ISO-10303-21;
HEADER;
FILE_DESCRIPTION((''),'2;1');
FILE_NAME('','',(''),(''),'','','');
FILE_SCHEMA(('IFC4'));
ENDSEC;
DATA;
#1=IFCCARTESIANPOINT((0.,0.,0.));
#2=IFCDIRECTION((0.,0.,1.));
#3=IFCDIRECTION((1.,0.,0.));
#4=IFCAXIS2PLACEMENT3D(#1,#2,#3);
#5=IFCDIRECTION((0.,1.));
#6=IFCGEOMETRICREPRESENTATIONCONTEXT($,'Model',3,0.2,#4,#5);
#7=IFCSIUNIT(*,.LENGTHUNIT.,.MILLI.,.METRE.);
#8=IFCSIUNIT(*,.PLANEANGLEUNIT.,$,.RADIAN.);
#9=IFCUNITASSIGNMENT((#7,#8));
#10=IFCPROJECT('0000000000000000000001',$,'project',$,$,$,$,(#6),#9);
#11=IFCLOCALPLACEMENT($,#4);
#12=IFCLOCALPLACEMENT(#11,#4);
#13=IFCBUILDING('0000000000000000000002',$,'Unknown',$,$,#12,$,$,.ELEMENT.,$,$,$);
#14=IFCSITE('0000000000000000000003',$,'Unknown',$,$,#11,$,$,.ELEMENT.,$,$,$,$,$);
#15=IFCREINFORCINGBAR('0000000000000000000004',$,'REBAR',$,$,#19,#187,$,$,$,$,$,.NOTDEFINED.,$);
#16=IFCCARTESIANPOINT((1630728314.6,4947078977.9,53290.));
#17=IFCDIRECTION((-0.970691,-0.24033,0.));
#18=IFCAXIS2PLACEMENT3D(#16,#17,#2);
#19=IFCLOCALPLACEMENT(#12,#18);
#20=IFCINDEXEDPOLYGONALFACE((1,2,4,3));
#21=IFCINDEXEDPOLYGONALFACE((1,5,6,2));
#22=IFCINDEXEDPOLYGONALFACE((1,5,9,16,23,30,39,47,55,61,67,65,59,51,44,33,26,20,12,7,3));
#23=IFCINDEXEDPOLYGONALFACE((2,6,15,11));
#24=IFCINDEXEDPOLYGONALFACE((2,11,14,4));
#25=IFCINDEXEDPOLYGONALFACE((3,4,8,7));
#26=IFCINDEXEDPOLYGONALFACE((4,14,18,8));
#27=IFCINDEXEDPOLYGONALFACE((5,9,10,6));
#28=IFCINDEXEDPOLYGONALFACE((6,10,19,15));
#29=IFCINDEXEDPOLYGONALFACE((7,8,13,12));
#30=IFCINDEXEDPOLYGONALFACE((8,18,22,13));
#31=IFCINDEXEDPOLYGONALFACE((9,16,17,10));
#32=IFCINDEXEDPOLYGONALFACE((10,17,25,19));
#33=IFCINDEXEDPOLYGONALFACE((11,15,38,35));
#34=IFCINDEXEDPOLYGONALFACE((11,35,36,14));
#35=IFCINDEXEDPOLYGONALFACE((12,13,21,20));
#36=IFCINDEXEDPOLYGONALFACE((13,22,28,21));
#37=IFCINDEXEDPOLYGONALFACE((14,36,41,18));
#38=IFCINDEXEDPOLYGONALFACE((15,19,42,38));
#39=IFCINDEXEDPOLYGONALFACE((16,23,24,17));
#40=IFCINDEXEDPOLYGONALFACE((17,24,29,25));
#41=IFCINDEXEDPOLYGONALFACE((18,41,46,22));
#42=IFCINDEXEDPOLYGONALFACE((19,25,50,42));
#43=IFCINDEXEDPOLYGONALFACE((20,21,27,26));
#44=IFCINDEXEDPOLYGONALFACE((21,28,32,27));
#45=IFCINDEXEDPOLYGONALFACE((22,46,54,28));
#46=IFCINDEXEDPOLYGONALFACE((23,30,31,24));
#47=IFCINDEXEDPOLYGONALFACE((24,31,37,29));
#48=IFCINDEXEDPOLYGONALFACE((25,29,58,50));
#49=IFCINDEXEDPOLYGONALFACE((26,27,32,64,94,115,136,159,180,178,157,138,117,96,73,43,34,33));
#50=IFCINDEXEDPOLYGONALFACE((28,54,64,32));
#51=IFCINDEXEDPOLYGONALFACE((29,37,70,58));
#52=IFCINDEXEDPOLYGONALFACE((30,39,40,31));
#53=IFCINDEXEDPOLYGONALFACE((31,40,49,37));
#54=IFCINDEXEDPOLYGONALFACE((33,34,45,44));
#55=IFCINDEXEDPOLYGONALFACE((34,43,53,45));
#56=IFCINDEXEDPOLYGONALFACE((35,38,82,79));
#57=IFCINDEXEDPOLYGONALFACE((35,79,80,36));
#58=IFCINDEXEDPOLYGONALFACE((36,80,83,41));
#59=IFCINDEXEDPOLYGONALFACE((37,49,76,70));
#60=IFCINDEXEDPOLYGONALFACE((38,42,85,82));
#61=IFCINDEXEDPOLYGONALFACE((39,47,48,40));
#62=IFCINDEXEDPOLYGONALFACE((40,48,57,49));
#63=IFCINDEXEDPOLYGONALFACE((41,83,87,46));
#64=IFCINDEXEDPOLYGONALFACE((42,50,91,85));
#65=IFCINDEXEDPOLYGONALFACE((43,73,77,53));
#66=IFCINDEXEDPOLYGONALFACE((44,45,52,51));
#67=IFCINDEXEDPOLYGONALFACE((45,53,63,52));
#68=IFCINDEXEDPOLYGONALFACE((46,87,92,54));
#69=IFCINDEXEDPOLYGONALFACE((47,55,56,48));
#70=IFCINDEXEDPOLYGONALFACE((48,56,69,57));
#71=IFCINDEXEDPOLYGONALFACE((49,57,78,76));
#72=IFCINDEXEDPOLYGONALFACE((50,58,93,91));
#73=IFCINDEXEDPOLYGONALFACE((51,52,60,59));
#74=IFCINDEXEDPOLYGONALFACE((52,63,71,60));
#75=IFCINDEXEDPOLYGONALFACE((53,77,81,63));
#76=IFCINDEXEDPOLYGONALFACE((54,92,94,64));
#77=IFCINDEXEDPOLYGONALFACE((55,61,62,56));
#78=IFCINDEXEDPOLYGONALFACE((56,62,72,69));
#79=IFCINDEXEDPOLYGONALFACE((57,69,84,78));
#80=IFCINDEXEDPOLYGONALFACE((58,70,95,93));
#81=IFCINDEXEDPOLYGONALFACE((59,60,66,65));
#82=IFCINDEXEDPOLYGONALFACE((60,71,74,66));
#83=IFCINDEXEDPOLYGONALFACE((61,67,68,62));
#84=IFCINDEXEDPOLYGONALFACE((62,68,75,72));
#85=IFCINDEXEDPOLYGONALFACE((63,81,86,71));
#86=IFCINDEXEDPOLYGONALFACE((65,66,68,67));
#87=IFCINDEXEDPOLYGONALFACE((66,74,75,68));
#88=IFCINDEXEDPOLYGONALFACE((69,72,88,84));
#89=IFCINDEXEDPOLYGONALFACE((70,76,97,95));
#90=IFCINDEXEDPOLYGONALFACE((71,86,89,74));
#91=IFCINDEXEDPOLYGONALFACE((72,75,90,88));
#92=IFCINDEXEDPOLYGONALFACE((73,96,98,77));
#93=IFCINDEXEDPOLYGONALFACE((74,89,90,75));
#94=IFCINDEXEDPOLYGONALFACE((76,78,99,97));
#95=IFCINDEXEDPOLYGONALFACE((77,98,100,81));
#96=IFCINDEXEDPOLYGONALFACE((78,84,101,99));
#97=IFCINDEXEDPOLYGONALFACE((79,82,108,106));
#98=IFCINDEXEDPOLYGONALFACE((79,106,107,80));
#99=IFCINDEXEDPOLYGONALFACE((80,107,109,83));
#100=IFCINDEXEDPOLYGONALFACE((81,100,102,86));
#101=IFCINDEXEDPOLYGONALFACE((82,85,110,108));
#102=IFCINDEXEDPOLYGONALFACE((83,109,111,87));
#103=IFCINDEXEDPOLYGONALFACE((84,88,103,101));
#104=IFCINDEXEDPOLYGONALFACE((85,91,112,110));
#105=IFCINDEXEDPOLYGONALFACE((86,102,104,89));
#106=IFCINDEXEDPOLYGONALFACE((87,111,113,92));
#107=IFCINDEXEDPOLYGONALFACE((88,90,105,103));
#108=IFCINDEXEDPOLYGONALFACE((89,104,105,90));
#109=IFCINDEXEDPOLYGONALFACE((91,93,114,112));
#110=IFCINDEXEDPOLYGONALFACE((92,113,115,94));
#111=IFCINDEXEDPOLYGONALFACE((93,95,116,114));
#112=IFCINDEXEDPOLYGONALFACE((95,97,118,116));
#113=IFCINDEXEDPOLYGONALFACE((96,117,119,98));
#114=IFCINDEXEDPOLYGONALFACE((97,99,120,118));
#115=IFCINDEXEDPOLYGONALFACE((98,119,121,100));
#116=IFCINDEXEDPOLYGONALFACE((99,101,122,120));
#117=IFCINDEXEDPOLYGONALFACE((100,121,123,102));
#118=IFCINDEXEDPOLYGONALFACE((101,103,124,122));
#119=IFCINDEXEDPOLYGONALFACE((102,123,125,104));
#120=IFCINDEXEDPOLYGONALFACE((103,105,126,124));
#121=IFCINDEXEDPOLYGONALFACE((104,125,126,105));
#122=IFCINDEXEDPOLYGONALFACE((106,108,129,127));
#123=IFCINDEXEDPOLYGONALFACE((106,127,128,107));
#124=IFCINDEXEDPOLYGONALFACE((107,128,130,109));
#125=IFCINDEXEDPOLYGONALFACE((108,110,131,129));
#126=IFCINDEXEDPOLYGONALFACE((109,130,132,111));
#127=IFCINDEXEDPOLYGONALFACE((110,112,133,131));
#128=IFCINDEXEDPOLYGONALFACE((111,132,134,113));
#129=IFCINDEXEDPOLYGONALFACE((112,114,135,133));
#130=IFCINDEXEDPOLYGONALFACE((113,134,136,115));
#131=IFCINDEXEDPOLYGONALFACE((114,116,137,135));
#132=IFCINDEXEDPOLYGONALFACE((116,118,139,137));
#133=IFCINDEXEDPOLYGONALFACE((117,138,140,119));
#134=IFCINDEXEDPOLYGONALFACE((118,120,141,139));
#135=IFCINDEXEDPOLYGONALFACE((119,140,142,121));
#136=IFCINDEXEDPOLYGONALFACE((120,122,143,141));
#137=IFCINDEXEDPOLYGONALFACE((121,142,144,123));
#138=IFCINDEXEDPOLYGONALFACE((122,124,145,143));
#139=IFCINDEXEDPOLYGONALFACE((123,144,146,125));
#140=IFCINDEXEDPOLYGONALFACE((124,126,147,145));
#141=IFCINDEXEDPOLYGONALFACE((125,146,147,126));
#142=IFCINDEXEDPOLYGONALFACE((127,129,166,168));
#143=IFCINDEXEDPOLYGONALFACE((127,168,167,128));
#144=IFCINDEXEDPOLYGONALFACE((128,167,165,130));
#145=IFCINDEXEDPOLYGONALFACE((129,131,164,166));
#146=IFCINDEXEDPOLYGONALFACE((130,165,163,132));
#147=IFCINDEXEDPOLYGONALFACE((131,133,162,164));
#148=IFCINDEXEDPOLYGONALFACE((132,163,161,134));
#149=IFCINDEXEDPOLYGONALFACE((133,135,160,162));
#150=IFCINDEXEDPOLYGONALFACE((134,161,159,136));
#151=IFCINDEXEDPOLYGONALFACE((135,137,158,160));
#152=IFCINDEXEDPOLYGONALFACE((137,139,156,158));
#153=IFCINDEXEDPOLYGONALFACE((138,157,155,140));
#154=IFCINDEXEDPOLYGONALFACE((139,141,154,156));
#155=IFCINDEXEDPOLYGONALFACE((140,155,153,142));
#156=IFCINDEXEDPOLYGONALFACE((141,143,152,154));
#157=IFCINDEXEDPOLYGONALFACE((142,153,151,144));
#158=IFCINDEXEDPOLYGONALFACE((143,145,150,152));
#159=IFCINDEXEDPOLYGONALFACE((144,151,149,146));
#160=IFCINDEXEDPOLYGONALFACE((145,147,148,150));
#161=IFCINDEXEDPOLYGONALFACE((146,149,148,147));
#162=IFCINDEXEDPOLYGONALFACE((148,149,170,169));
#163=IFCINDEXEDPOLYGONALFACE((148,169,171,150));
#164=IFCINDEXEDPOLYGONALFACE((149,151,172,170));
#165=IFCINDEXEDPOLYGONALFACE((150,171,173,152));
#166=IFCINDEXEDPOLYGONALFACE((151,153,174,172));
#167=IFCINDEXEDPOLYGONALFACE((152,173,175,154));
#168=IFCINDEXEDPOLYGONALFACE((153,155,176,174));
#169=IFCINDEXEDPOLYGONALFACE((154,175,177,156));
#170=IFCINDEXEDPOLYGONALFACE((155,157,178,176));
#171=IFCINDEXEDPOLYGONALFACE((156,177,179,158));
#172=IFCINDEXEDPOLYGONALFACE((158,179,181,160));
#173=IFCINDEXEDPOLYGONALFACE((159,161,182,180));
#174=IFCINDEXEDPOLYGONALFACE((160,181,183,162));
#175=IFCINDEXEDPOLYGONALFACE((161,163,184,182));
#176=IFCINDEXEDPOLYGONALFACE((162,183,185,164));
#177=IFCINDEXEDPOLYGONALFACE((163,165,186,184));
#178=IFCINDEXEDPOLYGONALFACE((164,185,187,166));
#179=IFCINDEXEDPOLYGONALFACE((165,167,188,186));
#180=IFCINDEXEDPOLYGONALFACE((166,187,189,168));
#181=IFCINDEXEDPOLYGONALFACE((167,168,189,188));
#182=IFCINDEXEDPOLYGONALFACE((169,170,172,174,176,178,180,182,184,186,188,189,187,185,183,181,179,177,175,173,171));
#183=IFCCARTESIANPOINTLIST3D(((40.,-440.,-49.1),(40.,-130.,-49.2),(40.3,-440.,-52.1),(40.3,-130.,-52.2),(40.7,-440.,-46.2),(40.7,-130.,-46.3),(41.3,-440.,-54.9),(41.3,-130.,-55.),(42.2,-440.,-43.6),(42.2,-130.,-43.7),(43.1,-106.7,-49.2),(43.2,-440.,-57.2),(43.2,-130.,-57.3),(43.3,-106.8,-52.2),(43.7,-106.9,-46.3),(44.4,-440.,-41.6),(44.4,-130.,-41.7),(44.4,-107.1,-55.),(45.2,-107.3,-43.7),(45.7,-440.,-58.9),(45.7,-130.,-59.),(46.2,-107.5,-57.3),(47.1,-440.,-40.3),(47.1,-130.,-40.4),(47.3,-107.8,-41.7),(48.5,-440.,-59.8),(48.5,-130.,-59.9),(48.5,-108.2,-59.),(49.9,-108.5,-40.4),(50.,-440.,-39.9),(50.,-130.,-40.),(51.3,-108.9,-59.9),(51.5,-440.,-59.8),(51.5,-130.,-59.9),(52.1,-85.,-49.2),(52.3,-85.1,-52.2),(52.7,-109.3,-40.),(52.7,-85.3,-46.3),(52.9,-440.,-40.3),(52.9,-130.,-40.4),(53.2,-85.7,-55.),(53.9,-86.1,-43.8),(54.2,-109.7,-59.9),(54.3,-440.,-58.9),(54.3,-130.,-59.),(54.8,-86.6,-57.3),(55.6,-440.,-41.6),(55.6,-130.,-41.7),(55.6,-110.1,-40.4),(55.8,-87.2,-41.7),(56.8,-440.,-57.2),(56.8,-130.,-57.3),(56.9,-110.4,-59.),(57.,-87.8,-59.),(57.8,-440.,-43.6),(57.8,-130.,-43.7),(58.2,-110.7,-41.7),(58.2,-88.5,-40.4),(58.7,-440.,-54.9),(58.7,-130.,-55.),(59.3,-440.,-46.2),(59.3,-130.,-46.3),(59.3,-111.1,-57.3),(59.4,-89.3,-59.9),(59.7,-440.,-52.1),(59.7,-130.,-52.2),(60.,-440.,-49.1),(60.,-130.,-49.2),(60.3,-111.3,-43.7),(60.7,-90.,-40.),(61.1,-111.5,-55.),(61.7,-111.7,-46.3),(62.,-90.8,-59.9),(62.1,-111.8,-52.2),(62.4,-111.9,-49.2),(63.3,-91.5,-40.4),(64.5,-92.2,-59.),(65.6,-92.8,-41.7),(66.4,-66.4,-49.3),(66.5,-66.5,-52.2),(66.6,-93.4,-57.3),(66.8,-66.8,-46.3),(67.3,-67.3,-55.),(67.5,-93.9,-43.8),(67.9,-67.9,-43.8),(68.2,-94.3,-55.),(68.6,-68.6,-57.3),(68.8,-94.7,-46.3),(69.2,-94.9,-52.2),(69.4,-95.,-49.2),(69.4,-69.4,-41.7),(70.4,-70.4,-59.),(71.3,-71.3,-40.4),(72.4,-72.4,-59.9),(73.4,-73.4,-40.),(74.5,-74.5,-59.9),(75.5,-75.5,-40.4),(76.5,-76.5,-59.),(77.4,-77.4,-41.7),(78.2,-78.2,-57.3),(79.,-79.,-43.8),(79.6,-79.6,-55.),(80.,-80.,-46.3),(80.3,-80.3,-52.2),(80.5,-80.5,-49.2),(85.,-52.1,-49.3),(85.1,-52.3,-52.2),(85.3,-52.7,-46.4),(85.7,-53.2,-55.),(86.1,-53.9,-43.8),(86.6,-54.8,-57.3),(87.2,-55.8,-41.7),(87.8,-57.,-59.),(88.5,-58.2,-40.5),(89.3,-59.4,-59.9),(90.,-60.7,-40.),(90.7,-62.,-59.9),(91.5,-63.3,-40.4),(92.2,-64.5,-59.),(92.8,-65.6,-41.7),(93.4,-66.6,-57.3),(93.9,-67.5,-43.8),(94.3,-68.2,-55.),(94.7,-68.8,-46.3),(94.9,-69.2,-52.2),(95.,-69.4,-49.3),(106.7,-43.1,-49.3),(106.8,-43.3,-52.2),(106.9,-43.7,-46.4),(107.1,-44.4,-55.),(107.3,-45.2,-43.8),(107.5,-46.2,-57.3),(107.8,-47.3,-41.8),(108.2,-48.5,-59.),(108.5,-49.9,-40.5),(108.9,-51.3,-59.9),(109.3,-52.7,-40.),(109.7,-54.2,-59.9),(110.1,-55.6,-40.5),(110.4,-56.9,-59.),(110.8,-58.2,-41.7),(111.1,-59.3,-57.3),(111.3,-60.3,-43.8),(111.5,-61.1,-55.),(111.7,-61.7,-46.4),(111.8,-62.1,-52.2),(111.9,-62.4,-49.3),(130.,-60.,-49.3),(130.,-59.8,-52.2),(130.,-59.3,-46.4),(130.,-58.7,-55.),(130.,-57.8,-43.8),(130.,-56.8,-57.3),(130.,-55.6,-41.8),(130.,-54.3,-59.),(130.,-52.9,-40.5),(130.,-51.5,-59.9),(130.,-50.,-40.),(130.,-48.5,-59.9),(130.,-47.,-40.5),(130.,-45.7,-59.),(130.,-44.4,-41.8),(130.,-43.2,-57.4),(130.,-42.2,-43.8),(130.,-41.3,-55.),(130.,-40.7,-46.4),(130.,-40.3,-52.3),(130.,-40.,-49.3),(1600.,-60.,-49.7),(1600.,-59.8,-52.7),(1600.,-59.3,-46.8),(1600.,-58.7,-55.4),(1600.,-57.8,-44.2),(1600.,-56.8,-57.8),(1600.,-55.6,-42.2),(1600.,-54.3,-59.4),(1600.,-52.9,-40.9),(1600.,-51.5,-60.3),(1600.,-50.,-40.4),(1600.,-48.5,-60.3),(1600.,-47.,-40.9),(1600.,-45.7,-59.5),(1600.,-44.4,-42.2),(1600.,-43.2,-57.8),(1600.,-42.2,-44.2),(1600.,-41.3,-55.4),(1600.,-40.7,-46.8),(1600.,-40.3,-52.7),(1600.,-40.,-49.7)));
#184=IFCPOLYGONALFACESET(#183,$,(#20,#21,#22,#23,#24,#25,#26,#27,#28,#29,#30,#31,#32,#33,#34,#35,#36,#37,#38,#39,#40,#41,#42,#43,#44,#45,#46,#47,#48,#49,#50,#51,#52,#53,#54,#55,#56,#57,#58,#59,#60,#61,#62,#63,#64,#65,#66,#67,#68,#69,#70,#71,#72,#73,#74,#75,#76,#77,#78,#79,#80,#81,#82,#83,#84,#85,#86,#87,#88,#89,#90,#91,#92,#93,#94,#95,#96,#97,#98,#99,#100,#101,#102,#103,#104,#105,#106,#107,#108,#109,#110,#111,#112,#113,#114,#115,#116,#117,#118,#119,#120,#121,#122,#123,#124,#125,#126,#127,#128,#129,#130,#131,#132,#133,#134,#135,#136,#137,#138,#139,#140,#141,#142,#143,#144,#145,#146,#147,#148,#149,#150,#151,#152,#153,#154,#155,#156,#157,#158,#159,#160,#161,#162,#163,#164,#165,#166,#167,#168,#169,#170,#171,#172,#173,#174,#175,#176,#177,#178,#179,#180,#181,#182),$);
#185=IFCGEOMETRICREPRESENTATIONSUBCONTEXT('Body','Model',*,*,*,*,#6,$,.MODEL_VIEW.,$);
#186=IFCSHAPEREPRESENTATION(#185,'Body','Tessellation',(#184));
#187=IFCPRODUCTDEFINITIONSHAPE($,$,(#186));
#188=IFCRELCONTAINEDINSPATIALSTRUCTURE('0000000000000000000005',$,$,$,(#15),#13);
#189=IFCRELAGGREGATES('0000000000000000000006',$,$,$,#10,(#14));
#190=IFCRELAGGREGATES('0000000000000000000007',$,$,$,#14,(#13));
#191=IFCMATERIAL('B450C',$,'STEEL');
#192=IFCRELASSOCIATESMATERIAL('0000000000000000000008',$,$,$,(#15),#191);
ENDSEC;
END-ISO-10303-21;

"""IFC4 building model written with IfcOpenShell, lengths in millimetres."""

from ifc_helpers import new_model, entity, si_unit, direction, frame, origin_with_axes, place, context, subcontext, project, spatial, material, element, save


model = new_model("IFC4")

# Units and contexts
model_context = context("Model", 3, precision=0.2, world=origin_with_axes(), true_north=direction((0.0, 1.0)))
body_context = subcontext(model_context, "Body", "Model", "MODEL_VIEW")
ifc_project = project(units=[si_unit("LENGTHUNIT", "METRE", prefix="MILLI"), si_unit("PLANEANGLEUNIT", "RADIAN")], contexts=[model_context])

# Site, building
site_placement = place(None, origin_with_axes())
site = spatial("IfcSite", under=ifc_project, at=site_placement, Name="Unknown", CompositionType="ELEMENT")
building_placement = place(site_placement, origin_with_axes())
building = spatial("IfcBuilding", under=site, at=building_placement, Name="Unknown", CompositionType="ELEMENT")

# Reinforcing bar
ifc_material = material(Name="B450C", Category="STEEL")
reinforcing_bar_1_placement = place(building_placement, frame((1630728314.6, 4947078977.9, 53290.0), z_axis=(-0.970691, -0.24033, 0.0), x_axis=(0.0, 0.0, 1.0)))
element("IfcReinforcingBar", 1, at=reinforcing_bar_1_placement, inside=building, material=ifc_material, Name="REBAR", PredefinedType="NOTDEFINED", context=body_context, shape_type="AdvancedSweptSolid", body=[
    entity("IfcSweptDiskSolid", entity("IfcIndexedPolyCurve", entity("IfcCartesianPointList3D", [[50.0, -440.0, -49.9], [50.0, -130.0, -50.0], [73.4, -73.4, -50.0], [130.0, -50.0, -50.0], [1600.0, -50.0, -50.4]]), [entity("IfcLineIndex", [1, 2]), entity("IfcArcIndex", [2, 3, 4]), entity("IfcLineIndex", [4, 5])]), 10.0),
])

save(model, "model.ifc")
